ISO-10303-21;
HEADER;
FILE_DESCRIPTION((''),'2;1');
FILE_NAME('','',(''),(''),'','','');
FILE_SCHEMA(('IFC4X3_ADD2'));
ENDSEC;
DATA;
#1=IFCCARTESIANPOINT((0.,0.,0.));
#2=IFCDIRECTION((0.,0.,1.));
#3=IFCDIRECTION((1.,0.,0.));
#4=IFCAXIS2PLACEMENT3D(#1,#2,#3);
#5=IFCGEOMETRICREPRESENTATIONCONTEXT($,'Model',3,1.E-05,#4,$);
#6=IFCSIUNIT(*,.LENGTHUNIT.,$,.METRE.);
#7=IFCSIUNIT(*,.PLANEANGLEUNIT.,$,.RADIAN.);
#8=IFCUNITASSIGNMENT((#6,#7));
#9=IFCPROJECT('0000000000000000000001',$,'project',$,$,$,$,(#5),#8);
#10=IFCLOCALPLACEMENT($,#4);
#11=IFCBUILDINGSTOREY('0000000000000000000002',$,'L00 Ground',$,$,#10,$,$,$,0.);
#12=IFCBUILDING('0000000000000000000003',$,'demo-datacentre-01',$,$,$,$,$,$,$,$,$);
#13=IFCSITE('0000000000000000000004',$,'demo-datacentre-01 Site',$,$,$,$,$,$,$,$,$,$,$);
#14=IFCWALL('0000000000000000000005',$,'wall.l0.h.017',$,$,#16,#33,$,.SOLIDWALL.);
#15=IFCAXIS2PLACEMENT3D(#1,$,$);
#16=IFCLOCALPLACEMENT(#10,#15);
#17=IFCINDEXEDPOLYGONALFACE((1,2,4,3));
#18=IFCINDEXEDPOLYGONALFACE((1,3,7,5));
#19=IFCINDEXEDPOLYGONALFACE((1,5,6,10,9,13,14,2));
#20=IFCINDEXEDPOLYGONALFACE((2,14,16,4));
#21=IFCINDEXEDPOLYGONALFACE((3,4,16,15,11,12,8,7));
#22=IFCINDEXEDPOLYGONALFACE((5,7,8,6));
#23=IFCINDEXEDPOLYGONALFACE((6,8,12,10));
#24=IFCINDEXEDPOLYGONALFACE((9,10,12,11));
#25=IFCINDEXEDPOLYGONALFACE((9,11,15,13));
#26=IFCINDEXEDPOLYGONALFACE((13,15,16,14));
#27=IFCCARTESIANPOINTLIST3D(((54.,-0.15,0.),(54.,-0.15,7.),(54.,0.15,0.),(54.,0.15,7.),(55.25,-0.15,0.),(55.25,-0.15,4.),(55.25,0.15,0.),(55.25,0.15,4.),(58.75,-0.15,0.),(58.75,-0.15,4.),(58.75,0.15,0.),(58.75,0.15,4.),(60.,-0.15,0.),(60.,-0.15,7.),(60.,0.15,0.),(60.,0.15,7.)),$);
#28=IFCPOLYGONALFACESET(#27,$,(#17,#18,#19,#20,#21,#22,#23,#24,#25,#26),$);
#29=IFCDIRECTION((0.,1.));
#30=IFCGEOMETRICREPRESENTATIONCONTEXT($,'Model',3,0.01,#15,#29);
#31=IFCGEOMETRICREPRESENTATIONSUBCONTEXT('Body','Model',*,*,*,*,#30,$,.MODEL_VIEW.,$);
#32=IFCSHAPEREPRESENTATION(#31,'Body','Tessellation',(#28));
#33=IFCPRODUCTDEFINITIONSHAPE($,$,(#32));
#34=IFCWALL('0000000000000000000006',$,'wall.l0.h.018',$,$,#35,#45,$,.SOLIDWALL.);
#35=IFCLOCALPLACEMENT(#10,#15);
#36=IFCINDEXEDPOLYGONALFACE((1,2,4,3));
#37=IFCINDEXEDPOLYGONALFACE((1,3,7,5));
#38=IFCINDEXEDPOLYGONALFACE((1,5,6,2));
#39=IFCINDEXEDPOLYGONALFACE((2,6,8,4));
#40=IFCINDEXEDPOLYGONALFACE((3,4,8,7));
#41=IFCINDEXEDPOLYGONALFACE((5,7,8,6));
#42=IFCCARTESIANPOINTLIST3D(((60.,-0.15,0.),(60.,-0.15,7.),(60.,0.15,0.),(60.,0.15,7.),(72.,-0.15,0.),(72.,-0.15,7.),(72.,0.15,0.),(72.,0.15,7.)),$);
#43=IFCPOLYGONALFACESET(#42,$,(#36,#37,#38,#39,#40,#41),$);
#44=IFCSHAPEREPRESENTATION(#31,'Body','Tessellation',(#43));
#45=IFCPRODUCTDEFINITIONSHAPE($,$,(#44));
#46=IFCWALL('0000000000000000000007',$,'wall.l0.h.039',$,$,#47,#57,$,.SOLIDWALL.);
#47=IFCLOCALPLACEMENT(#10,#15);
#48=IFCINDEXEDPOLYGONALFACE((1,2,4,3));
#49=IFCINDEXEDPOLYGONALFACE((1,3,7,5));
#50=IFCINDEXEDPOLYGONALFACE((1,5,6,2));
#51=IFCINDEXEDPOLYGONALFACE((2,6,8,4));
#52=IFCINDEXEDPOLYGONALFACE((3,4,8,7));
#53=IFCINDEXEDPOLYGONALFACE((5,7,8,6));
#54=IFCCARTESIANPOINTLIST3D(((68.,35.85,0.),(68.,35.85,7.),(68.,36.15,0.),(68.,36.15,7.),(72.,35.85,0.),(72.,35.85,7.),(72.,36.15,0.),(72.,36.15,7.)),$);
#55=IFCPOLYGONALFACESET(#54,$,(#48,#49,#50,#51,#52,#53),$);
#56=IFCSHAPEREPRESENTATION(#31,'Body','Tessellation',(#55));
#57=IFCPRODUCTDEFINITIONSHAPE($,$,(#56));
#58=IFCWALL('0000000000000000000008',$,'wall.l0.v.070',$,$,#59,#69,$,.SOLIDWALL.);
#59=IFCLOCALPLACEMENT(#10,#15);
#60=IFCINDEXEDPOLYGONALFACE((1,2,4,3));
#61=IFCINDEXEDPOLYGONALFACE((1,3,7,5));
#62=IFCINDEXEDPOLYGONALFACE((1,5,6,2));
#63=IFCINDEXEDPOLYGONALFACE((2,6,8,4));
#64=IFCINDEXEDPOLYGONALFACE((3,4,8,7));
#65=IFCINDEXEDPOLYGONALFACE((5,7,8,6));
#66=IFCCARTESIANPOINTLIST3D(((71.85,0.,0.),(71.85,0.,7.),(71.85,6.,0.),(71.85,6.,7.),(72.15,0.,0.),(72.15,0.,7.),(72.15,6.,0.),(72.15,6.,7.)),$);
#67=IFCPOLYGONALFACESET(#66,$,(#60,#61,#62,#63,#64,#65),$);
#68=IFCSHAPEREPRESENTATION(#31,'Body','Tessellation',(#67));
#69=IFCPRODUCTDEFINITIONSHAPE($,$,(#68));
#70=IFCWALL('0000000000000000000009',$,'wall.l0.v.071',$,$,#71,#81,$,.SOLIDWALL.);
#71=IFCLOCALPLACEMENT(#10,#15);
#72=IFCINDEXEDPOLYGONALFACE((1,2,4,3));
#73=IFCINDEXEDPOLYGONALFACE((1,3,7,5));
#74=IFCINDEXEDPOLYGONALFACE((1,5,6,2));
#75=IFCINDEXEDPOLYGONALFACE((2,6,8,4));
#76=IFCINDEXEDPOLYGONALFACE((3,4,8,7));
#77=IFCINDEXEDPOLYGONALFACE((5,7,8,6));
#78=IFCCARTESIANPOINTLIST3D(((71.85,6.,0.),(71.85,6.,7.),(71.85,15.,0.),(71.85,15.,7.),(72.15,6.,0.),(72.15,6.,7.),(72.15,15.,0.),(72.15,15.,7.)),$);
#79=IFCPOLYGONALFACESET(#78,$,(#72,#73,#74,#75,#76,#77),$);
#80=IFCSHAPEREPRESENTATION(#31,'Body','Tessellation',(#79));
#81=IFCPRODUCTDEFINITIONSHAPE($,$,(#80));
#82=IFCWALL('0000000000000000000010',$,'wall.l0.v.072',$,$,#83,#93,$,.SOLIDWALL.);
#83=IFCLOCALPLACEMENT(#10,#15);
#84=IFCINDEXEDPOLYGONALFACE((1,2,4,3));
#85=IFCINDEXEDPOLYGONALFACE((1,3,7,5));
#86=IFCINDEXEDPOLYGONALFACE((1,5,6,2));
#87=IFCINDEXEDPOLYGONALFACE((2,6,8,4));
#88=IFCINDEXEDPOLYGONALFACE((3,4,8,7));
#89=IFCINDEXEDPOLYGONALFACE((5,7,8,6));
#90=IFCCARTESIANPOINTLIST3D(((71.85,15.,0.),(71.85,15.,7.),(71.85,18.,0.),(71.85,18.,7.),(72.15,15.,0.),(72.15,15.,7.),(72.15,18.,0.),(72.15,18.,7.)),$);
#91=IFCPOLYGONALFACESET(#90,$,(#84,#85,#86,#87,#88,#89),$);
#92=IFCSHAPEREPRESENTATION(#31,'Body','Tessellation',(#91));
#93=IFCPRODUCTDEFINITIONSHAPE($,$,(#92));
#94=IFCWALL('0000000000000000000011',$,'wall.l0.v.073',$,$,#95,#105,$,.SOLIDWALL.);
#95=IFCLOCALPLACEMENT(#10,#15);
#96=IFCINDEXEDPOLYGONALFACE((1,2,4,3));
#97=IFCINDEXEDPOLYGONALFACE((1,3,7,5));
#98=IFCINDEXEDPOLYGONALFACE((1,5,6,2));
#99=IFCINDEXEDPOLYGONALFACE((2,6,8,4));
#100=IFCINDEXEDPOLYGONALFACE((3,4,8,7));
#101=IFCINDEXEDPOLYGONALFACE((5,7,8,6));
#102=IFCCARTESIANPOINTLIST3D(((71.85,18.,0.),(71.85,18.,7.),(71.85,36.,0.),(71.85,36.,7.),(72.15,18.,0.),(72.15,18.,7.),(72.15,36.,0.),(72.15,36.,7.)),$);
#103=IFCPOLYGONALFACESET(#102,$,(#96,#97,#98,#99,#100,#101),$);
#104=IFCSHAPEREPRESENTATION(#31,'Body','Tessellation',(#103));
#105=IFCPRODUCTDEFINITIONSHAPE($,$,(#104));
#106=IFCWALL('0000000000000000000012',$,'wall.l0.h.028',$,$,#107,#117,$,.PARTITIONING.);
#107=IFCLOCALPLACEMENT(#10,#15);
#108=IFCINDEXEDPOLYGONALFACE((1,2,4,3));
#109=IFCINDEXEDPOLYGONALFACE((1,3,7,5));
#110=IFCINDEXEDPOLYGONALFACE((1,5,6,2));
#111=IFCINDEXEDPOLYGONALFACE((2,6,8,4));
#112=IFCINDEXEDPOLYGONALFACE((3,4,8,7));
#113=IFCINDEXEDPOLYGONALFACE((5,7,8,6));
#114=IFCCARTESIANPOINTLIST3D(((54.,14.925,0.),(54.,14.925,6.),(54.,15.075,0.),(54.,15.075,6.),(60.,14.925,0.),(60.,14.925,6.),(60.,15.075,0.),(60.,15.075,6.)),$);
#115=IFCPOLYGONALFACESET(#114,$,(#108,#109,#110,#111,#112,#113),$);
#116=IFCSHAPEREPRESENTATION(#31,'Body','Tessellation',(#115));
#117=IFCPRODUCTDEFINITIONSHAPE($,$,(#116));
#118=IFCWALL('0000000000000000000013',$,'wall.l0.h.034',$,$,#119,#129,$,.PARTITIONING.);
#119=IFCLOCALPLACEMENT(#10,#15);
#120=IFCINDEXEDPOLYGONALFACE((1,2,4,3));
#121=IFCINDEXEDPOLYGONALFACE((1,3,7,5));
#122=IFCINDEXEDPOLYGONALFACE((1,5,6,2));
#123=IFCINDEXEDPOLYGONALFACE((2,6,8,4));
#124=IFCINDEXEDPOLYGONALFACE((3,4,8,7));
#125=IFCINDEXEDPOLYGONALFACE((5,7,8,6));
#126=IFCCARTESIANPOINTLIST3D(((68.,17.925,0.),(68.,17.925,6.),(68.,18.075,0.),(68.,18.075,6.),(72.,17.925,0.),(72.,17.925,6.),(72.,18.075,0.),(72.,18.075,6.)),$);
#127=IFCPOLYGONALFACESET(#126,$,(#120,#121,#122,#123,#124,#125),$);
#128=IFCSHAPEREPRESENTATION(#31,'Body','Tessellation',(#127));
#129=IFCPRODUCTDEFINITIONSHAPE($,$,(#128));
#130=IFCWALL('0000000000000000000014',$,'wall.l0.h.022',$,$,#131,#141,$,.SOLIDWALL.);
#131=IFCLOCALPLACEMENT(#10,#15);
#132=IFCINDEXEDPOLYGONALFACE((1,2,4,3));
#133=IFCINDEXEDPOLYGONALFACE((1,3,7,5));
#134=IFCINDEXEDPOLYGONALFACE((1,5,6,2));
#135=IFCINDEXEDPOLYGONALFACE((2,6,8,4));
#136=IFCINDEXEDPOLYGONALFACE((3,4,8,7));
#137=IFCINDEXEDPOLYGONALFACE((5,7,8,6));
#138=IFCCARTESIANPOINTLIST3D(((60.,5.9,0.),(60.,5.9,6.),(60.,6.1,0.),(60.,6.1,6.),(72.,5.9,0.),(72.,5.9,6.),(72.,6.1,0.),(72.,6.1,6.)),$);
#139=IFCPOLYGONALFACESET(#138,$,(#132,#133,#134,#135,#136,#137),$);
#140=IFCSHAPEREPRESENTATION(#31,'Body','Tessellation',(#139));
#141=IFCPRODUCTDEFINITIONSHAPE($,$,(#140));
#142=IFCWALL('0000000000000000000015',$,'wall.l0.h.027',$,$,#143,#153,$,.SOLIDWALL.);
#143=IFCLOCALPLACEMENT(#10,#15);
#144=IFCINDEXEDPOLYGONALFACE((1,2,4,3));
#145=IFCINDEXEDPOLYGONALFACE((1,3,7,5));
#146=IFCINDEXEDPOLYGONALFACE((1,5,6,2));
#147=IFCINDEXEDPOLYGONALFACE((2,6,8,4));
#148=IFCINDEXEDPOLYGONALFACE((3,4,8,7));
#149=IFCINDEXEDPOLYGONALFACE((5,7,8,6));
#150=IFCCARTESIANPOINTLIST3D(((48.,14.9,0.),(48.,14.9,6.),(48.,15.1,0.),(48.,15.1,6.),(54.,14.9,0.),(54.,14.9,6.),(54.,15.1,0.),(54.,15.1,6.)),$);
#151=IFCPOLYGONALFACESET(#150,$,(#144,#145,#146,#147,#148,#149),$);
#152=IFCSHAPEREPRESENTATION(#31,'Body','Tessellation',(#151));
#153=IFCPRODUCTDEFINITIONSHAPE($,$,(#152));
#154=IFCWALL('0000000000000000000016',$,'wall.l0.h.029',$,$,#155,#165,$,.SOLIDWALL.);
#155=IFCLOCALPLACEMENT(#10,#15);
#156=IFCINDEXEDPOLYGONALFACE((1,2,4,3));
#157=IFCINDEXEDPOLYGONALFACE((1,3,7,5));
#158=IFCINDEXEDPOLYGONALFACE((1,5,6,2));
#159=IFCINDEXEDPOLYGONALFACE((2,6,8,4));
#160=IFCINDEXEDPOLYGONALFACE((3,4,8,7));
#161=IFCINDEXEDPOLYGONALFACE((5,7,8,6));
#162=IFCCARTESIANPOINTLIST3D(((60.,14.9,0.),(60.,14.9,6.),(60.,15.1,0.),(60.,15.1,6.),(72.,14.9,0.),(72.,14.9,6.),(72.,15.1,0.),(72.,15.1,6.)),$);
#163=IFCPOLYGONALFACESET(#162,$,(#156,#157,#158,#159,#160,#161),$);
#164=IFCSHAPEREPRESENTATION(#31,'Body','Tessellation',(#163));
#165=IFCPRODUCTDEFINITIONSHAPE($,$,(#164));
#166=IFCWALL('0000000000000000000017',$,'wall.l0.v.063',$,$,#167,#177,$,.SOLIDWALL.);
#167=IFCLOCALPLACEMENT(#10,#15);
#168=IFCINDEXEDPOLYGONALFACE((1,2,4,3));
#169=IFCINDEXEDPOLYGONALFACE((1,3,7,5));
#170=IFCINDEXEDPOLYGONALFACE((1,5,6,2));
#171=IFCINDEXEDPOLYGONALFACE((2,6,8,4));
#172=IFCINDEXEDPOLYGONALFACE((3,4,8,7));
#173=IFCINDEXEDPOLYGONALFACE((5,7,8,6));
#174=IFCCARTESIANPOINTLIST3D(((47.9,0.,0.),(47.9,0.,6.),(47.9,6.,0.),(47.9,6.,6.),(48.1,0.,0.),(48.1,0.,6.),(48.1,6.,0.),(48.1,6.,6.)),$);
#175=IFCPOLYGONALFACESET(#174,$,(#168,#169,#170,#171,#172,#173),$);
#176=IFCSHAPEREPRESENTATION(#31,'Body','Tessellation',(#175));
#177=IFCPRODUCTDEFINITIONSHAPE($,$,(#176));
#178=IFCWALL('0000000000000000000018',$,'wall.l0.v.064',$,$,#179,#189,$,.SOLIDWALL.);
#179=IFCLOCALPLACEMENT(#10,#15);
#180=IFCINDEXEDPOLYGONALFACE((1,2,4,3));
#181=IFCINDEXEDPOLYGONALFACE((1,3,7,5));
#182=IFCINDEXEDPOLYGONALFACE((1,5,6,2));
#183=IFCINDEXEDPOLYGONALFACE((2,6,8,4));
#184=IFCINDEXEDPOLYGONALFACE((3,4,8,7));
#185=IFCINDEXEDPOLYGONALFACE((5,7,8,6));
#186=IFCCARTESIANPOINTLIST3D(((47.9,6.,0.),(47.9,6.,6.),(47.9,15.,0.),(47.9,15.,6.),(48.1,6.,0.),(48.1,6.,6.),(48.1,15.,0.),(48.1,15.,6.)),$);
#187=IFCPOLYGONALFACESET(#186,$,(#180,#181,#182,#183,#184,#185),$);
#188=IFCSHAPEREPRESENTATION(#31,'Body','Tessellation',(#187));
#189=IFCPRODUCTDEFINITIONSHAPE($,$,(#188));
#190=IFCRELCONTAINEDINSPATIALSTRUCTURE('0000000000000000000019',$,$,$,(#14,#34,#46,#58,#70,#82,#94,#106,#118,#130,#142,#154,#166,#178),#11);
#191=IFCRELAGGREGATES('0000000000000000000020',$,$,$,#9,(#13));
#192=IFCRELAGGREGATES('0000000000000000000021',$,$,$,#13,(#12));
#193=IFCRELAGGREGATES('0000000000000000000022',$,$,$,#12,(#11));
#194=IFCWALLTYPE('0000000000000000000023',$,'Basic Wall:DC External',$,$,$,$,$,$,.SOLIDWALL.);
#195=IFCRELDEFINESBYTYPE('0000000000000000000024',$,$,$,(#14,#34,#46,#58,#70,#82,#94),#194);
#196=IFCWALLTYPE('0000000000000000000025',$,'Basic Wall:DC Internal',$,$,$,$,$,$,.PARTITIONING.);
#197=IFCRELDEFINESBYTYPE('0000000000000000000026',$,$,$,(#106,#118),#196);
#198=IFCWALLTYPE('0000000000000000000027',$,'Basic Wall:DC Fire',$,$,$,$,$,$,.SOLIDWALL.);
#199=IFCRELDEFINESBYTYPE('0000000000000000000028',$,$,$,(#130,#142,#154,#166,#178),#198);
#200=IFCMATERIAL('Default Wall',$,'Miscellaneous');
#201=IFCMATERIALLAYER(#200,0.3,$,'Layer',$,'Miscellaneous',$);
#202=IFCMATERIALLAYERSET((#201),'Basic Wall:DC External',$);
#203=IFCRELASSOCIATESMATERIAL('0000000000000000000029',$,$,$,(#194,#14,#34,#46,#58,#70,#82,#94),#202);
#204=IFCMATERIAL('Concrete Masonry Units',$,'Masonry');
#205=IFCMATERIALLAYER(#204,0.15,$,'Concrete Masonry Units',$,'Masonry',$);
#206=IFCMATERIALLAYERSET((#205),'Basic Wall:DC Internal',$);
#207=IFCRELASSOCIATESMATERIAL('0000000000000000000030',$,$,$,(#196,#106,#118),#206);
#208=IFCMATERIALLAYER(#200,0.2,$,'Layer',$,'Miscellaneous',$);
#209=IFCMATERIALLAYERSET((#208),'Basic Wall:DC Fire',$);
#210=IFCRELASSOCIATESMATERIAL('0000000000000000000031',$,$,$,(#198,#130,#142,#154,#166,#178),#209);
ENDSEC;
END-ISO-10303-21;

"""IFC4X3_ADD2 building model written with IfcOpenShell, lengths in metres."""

from ifc_helpers import new_model, si_unit, direction, frame, frame_2d, origin, origin_with_axes, origin_2d_with_axis, place, context, subcontext, project, spatial, rectangle, extrude, material, layer, layer_set, type_object, element, save


model = new_model("IFC4X3_ADD2")

# Units and contexts
model_context_1 = context("Model", 3, precision=0.01, world=origin(), true_north=direction((0.0, 1.0)))
model_context_2 = context("Model", 3, precision=1e-05, world=origin_with_axes())
body_context = subcontext(model_context_1, "Body", "Model", "MODEL_VIEW")
ifc_project = project(units=[si_unit("LENGTHUNIT", "METRE"), si_unit("PLANEANGLEUNIT", "RADIAN")], contexts=[model_context_2])

# Site, building, storey
site = spatial("IfcSite", under=ifc_project, Name="demo-datacentre-01 Site")
building = spatial("IfcBuilding", under=site, Name="demo-datacentre-01")
storey_placement = place(None, origin_with_axes())
storey = spatial("IfcBuildingStorey", under=building, at=storey_placement, Name="L00 Ground", Elevation=0.0)

# Wall, opening
ifc_material_1 = material(Name="Default Wall", Category="Miscellaneous")
ifc_layer_1 = layer(ifc_material_1, 0.3, Name="Layer", Category="Miscellaneous")
ifc_layer_set_1 = layer_set([ifc_layer_1], Name="Basic Wall:DC External")
wall_type_1 = type_object("IfcWallType", Name="Basic Wall:DC External", PredefinedType="SOLIDWALL", material=ifc_layer_set_1)
placement_1 = place(None, origin())
placement_2 = place(placement_1, origin())
placement_3 = place(placement_2, origin())
wall_1_placement = place(placement_3, frame((54.0, 0.0, 0.0)))
wall_1 = element("IfcWall", 1, at=wall_1_placement, inside=storey, type_object=wall_type_1, material=ifc_layer_set_1, Name="wall.l0.h.017", PredefinedType="SOLIDWALL", context=body_context, shape_type="SweptSolid", body=[
    extrude(rectangle(XDim=6.0, YDim=0.3, at=frame_2d((3.0, 0.0), x_axis=(1.0, 0.0))), origin(), (0.0, 0.0, 1.0), 7.0),
])
opening_placement = place(wall_1_placement, frame((1.25, -0.15, 0.0)))
element("IfcOpeningElement", 2, at=opening_placement, cuts=wall_1, PredefinedType="OPENING", context=body_context, shape_type="SweptSolid", body=[
    extrude(rectangle(XDim=4.0, YDim=3.5, at=origin_2d_with_axis()), frame((1.75, 0.0, 2.0), z_axis=(0.0, 1.0, 0.0), x_axis=(0.0, 0.0, -1.0)), (0.0, 0.0, 1.0), 0.3),
])

# Walls
wall_2_placement = place(placement_3, frame((60.0, 0.0, 0.0)))
element("IfcWall", 3, at=wall_2_placement, inside=storey, type_object=wall_type_1, material=ifc_layer_set_1, Name="wall.l0.h.018", PredefinedType="SOLIDWALL", context=body_context, shape_type="SweptSolid", body=[
    extrude(rectangle(XDim=12.0, YDim=0.3, at=frame_2d((6.0, 0.0), x_axis=(-1.0, 0.0))), origin(), (0.0, 0.0, 1.0), 7.0),
])
wall_3_placement = place(placement_3, frame((68.0, 36.0, 0.0)))
element("IfcWall", 4, at=wall_3_placement, inside=storey, type_object=wall_type_1, material=ifc_layer_set_1, Name="wall.l0.h.039", PredefinedType="SOLIDWALL", context=body_context, shape_type="SweptSolid", body=[
    extrude(rectangle(XDim=4.0, YDim=0.3, at=frame_2d((2.0, 0.0), x_axis=(-1.0, 0.0))), origin(), (0.0, 0.0, 1.0), 7.0),
])
wall_4_placement = place(placement_3, frame((72.0, 0.0, 0.0), z_axis=(0.0, 0.0, 1.0), x_axis=(0.0, 1.0, 0.0)))
element("IfcWall", 5, at=wall_4_placement, inside=storey, type_object=wall_type_1, material=ifc_layer_set_1, Name="wall.l0.v.070", PredefinedType="SOLIDWALL", context=body_context, shape_type="SweptSolid", body=[
    extrude(rectangle(XDim=6.0, YDim=0.3, at=frame_2d((3.0, 0.0), x_axis=(-1.0, 0.0))), origin(), (0.0, 0.0, 1.0), 7.0),
])
wall_5_placement = place(placement_3, frame((72.0, 6.0, 0.0), z_axis=(0.0, 0.0, 1.0), x_axis=(0.0, 1.0, 0.0)))
element("IfcWall", 6, at=wall_5_placement, inside=storey, type_object=wall_type_1, material=ifc_layer_set_1, Name="wall.l0.v.071", PredefinedType="SOLIDWALL", context=body_context, shape_type="SweptSolid", body=[
    extrude(rectangle(XDim=9.0, YDim=0.3, at=frame_2d((4.5, 0.0), x_axis=(-1.0, 0.0))), origin(), (0.0, 0.0, 1.0), 7.0),
])
wall_6_placement = place(placement_3, frame((72.0, 15.0, 0.0), z_axis=(0.0, 0.0, 1.0), x_axis=(0.0, 1.0, 0.0)))
element("IfcWall", 7, at=wall_6_placement, inside=storey, type_object=wall_type_1, material=ifc_layer_set_1, Name="wall.l0.v.072", PredefinedType="SOLIDWALL", context=body_context, shape_type="SweptSolid", body=[
    extrude(rectangle(XDim=3.0, YDim=0.3, at=frame_2d((1.5, 0.0), x_axis=(-1.0, 0.0))), origin(), (0.0, 0.0, 1.0), 7.0),
])
wall_7_placement = place(placement_3, frame((72.0, 18.0, 0.0), z_axis=(0.0, 0.0, 1.0), x_axis=(0.0, 1.0, 0.0)))
element("IfcWall", 8, at=wall_7_placement, inside=storey, type_object=wall_type_1, material=ifc_layer_set_1, Name="wall.l0.v.073", PredefinedType="SOLIDWALL", context=body_context, shape_type="SweptSolid", body=[
    extrude(rectangle(XDim=18.0, YDim=0.3, at=frame_2d((9.0, 0.0), x_axis=(-1.0, 0.0))), origin(), (0.0, 0.0, 1.0), 7.0),
])
ifc_material_2 = material(Name="Concrete Masonry Units", Category="Masonry")
ifc_layer_2 = layer(ifc_material_2, 0.15, Name="Concrete Masonry Units", Category="Masonry")
ifc_layer_set_2 = layer_set([ifc_layer_2], Name="Basic Wall:DC Internal")
wall_type_2 = type_object("IfcWallType", Name="Basic Wall:DC Internal", PredefinedType="PARTITIONING", material=ifc_layer_set_2)
wall_8_placement = place(placement_3, frame((54.0, 15.0, 0.0)))
element("IfcWall", 9, at=wall_8_placement, inside=storey, type_object=wall_type_2, material=ifc_layer_set_2, Name="wall.l0.h.028", PredefinedType="PARTITIONING", context=body_context, shape_type="SweptSolid", body=[
    extrude(rectangle(XDim=6.0, YDim=0.15, at=frame_2d((3.0, 0.0), x_axis=(-1.0, 0.0))), origin(), (0.0, 0.0, 1.0), 6.0),
])
wall_9_placement = place(placement_3, frame((68.0, 18.0, 0.0)))
element("IfcWall", 10, at=wall_9_placement, inside=storey, type_object=wall_type_2, material=ifc_layer_set_2, Name="wall.l0.h.034", PredefinedType="PARTITIONING", context=body_context, shape_type="SweptSolid", body=[
    extrude(rectangle(XDim=4.0, YDim=0.15, at=frame_2d((2.0, 0.0), x_axis=(-1.0, 0.0))), origin(), (0.0, 0.0, 1.0), 6.0),
])
ifc_layer_3 = layer(ifc_material_1, 0.2, Name="Layer", Category="Miscellaneous")
ifc_layer_set_3 = layer_set([ifc_layer_3], Name="Basic Wall:DC Fire")
wall_type_3 = type_object("IfcWallType", Name="Basic Wall:DC Fire", PredefinedType="SOLIDWALL", material=ifc_layer_set_3)
wall_10_placement = place(placement_3, frame((60.0, 6.0, 0.0)))
element("IfcWall", 11, at=wall_10_placement, inside=storey, type_object=wall_type_3, material=ifc_layer_set_3, Name="wall.l0.h.022", PredefinedType="SOLIDWALL", context=body_context, shape_type="SweptSolid", body=[
    extrude(rectangle(XDim=12.0, YDim=0.2, at=frame_2d((6.0, 0.0), x_axis=(-1.0, 0.0))), origin(), (0.0, 0.0, 1.0), 6.0),
])
wall_11_placement = place(placement_3, frame((48.0, 15.0, 0.0)))
element("IfcWall", 12, at=wall_11_placement, inside=storey, type_object=wall_type_3, material=ifc_layer_set_3, Name="wall.l0.h.027", PredefinedType="SOLIDWALL", context=body_context, shape_type="SweptSolid", body=[
    extrude(rectangle(XDim=6.0, YDim=0.2, at=frame_2d((3.0, 0.0), x_axis=(-1.0, 0.0))), origin(), (0.0, 0.0, 1.0), 6.0),
])
wall_12_placement = place(placement_3, frame((60.0, 15.0, 0.0)))
element("IfcWall", 13, at=wall_12_placement, inside=storey, type_object=wall_type_3, material=ifc_layer_set_3, Name="wall.l0.h.029", PredefinedType="SOLIDWALL", context=body_context, shape_type="SweptSolid", body=[
    extrude(rectangle(XDim=12.0, YDim=0.2, at=frame_2d((6.0, 0.0), x_axis=(-1.0, 0.0))), origin(), (0.0, 0.0, 1.0), 6.0),
])
wall_13_placement = place(placement_3, frame((48.0, 0.0, 0.0), z_axis=(0.0, 0.0, 1.0), x_axis=(0.0, 1.0, 0.0)))
element("IfcWall", 14, at=wall_13_placement, inside=storey, type_object=wall_type_3, material=ifc_layer_set_3, Name="wall.l0.v.063", PredefinedType="SOLIDWALL", context=body_context, shape_type="SweptSolid", body=[
    extrude(rectangle(XDim=6.0, YDim=0.2, at=frame_2d((3.0, 0.0), x_axis=(-1.0, 0.0))), origin(), (0.0, 0.0, 1.0), 6.0),
])
wall_14_placement = place(placement_3, frame((48.0, 6.0, 0.0), z_axis=(0.0, 0.0, 1.0), x_axis=(0.0, 1.0, 0.0)))
element("IfcWall", 15, at=wall_14_placement, inside=storey, type_object=wall_type_3, material=ifc_layer_set_3, Name="wall.l0.v.064", PredefinedType="SOLIDWALL", context=body_context, shape_type="SweptSolid", body=[
    extrude(rectangle(XDim=9.0, YDim=0.2, at=frame_2d((4.5, 0.0), x_axis=(-1.0, 0.0))), origin(), (0.0, 0.0, 1.0), 6.0),
])

save(model, "model.ifc")
